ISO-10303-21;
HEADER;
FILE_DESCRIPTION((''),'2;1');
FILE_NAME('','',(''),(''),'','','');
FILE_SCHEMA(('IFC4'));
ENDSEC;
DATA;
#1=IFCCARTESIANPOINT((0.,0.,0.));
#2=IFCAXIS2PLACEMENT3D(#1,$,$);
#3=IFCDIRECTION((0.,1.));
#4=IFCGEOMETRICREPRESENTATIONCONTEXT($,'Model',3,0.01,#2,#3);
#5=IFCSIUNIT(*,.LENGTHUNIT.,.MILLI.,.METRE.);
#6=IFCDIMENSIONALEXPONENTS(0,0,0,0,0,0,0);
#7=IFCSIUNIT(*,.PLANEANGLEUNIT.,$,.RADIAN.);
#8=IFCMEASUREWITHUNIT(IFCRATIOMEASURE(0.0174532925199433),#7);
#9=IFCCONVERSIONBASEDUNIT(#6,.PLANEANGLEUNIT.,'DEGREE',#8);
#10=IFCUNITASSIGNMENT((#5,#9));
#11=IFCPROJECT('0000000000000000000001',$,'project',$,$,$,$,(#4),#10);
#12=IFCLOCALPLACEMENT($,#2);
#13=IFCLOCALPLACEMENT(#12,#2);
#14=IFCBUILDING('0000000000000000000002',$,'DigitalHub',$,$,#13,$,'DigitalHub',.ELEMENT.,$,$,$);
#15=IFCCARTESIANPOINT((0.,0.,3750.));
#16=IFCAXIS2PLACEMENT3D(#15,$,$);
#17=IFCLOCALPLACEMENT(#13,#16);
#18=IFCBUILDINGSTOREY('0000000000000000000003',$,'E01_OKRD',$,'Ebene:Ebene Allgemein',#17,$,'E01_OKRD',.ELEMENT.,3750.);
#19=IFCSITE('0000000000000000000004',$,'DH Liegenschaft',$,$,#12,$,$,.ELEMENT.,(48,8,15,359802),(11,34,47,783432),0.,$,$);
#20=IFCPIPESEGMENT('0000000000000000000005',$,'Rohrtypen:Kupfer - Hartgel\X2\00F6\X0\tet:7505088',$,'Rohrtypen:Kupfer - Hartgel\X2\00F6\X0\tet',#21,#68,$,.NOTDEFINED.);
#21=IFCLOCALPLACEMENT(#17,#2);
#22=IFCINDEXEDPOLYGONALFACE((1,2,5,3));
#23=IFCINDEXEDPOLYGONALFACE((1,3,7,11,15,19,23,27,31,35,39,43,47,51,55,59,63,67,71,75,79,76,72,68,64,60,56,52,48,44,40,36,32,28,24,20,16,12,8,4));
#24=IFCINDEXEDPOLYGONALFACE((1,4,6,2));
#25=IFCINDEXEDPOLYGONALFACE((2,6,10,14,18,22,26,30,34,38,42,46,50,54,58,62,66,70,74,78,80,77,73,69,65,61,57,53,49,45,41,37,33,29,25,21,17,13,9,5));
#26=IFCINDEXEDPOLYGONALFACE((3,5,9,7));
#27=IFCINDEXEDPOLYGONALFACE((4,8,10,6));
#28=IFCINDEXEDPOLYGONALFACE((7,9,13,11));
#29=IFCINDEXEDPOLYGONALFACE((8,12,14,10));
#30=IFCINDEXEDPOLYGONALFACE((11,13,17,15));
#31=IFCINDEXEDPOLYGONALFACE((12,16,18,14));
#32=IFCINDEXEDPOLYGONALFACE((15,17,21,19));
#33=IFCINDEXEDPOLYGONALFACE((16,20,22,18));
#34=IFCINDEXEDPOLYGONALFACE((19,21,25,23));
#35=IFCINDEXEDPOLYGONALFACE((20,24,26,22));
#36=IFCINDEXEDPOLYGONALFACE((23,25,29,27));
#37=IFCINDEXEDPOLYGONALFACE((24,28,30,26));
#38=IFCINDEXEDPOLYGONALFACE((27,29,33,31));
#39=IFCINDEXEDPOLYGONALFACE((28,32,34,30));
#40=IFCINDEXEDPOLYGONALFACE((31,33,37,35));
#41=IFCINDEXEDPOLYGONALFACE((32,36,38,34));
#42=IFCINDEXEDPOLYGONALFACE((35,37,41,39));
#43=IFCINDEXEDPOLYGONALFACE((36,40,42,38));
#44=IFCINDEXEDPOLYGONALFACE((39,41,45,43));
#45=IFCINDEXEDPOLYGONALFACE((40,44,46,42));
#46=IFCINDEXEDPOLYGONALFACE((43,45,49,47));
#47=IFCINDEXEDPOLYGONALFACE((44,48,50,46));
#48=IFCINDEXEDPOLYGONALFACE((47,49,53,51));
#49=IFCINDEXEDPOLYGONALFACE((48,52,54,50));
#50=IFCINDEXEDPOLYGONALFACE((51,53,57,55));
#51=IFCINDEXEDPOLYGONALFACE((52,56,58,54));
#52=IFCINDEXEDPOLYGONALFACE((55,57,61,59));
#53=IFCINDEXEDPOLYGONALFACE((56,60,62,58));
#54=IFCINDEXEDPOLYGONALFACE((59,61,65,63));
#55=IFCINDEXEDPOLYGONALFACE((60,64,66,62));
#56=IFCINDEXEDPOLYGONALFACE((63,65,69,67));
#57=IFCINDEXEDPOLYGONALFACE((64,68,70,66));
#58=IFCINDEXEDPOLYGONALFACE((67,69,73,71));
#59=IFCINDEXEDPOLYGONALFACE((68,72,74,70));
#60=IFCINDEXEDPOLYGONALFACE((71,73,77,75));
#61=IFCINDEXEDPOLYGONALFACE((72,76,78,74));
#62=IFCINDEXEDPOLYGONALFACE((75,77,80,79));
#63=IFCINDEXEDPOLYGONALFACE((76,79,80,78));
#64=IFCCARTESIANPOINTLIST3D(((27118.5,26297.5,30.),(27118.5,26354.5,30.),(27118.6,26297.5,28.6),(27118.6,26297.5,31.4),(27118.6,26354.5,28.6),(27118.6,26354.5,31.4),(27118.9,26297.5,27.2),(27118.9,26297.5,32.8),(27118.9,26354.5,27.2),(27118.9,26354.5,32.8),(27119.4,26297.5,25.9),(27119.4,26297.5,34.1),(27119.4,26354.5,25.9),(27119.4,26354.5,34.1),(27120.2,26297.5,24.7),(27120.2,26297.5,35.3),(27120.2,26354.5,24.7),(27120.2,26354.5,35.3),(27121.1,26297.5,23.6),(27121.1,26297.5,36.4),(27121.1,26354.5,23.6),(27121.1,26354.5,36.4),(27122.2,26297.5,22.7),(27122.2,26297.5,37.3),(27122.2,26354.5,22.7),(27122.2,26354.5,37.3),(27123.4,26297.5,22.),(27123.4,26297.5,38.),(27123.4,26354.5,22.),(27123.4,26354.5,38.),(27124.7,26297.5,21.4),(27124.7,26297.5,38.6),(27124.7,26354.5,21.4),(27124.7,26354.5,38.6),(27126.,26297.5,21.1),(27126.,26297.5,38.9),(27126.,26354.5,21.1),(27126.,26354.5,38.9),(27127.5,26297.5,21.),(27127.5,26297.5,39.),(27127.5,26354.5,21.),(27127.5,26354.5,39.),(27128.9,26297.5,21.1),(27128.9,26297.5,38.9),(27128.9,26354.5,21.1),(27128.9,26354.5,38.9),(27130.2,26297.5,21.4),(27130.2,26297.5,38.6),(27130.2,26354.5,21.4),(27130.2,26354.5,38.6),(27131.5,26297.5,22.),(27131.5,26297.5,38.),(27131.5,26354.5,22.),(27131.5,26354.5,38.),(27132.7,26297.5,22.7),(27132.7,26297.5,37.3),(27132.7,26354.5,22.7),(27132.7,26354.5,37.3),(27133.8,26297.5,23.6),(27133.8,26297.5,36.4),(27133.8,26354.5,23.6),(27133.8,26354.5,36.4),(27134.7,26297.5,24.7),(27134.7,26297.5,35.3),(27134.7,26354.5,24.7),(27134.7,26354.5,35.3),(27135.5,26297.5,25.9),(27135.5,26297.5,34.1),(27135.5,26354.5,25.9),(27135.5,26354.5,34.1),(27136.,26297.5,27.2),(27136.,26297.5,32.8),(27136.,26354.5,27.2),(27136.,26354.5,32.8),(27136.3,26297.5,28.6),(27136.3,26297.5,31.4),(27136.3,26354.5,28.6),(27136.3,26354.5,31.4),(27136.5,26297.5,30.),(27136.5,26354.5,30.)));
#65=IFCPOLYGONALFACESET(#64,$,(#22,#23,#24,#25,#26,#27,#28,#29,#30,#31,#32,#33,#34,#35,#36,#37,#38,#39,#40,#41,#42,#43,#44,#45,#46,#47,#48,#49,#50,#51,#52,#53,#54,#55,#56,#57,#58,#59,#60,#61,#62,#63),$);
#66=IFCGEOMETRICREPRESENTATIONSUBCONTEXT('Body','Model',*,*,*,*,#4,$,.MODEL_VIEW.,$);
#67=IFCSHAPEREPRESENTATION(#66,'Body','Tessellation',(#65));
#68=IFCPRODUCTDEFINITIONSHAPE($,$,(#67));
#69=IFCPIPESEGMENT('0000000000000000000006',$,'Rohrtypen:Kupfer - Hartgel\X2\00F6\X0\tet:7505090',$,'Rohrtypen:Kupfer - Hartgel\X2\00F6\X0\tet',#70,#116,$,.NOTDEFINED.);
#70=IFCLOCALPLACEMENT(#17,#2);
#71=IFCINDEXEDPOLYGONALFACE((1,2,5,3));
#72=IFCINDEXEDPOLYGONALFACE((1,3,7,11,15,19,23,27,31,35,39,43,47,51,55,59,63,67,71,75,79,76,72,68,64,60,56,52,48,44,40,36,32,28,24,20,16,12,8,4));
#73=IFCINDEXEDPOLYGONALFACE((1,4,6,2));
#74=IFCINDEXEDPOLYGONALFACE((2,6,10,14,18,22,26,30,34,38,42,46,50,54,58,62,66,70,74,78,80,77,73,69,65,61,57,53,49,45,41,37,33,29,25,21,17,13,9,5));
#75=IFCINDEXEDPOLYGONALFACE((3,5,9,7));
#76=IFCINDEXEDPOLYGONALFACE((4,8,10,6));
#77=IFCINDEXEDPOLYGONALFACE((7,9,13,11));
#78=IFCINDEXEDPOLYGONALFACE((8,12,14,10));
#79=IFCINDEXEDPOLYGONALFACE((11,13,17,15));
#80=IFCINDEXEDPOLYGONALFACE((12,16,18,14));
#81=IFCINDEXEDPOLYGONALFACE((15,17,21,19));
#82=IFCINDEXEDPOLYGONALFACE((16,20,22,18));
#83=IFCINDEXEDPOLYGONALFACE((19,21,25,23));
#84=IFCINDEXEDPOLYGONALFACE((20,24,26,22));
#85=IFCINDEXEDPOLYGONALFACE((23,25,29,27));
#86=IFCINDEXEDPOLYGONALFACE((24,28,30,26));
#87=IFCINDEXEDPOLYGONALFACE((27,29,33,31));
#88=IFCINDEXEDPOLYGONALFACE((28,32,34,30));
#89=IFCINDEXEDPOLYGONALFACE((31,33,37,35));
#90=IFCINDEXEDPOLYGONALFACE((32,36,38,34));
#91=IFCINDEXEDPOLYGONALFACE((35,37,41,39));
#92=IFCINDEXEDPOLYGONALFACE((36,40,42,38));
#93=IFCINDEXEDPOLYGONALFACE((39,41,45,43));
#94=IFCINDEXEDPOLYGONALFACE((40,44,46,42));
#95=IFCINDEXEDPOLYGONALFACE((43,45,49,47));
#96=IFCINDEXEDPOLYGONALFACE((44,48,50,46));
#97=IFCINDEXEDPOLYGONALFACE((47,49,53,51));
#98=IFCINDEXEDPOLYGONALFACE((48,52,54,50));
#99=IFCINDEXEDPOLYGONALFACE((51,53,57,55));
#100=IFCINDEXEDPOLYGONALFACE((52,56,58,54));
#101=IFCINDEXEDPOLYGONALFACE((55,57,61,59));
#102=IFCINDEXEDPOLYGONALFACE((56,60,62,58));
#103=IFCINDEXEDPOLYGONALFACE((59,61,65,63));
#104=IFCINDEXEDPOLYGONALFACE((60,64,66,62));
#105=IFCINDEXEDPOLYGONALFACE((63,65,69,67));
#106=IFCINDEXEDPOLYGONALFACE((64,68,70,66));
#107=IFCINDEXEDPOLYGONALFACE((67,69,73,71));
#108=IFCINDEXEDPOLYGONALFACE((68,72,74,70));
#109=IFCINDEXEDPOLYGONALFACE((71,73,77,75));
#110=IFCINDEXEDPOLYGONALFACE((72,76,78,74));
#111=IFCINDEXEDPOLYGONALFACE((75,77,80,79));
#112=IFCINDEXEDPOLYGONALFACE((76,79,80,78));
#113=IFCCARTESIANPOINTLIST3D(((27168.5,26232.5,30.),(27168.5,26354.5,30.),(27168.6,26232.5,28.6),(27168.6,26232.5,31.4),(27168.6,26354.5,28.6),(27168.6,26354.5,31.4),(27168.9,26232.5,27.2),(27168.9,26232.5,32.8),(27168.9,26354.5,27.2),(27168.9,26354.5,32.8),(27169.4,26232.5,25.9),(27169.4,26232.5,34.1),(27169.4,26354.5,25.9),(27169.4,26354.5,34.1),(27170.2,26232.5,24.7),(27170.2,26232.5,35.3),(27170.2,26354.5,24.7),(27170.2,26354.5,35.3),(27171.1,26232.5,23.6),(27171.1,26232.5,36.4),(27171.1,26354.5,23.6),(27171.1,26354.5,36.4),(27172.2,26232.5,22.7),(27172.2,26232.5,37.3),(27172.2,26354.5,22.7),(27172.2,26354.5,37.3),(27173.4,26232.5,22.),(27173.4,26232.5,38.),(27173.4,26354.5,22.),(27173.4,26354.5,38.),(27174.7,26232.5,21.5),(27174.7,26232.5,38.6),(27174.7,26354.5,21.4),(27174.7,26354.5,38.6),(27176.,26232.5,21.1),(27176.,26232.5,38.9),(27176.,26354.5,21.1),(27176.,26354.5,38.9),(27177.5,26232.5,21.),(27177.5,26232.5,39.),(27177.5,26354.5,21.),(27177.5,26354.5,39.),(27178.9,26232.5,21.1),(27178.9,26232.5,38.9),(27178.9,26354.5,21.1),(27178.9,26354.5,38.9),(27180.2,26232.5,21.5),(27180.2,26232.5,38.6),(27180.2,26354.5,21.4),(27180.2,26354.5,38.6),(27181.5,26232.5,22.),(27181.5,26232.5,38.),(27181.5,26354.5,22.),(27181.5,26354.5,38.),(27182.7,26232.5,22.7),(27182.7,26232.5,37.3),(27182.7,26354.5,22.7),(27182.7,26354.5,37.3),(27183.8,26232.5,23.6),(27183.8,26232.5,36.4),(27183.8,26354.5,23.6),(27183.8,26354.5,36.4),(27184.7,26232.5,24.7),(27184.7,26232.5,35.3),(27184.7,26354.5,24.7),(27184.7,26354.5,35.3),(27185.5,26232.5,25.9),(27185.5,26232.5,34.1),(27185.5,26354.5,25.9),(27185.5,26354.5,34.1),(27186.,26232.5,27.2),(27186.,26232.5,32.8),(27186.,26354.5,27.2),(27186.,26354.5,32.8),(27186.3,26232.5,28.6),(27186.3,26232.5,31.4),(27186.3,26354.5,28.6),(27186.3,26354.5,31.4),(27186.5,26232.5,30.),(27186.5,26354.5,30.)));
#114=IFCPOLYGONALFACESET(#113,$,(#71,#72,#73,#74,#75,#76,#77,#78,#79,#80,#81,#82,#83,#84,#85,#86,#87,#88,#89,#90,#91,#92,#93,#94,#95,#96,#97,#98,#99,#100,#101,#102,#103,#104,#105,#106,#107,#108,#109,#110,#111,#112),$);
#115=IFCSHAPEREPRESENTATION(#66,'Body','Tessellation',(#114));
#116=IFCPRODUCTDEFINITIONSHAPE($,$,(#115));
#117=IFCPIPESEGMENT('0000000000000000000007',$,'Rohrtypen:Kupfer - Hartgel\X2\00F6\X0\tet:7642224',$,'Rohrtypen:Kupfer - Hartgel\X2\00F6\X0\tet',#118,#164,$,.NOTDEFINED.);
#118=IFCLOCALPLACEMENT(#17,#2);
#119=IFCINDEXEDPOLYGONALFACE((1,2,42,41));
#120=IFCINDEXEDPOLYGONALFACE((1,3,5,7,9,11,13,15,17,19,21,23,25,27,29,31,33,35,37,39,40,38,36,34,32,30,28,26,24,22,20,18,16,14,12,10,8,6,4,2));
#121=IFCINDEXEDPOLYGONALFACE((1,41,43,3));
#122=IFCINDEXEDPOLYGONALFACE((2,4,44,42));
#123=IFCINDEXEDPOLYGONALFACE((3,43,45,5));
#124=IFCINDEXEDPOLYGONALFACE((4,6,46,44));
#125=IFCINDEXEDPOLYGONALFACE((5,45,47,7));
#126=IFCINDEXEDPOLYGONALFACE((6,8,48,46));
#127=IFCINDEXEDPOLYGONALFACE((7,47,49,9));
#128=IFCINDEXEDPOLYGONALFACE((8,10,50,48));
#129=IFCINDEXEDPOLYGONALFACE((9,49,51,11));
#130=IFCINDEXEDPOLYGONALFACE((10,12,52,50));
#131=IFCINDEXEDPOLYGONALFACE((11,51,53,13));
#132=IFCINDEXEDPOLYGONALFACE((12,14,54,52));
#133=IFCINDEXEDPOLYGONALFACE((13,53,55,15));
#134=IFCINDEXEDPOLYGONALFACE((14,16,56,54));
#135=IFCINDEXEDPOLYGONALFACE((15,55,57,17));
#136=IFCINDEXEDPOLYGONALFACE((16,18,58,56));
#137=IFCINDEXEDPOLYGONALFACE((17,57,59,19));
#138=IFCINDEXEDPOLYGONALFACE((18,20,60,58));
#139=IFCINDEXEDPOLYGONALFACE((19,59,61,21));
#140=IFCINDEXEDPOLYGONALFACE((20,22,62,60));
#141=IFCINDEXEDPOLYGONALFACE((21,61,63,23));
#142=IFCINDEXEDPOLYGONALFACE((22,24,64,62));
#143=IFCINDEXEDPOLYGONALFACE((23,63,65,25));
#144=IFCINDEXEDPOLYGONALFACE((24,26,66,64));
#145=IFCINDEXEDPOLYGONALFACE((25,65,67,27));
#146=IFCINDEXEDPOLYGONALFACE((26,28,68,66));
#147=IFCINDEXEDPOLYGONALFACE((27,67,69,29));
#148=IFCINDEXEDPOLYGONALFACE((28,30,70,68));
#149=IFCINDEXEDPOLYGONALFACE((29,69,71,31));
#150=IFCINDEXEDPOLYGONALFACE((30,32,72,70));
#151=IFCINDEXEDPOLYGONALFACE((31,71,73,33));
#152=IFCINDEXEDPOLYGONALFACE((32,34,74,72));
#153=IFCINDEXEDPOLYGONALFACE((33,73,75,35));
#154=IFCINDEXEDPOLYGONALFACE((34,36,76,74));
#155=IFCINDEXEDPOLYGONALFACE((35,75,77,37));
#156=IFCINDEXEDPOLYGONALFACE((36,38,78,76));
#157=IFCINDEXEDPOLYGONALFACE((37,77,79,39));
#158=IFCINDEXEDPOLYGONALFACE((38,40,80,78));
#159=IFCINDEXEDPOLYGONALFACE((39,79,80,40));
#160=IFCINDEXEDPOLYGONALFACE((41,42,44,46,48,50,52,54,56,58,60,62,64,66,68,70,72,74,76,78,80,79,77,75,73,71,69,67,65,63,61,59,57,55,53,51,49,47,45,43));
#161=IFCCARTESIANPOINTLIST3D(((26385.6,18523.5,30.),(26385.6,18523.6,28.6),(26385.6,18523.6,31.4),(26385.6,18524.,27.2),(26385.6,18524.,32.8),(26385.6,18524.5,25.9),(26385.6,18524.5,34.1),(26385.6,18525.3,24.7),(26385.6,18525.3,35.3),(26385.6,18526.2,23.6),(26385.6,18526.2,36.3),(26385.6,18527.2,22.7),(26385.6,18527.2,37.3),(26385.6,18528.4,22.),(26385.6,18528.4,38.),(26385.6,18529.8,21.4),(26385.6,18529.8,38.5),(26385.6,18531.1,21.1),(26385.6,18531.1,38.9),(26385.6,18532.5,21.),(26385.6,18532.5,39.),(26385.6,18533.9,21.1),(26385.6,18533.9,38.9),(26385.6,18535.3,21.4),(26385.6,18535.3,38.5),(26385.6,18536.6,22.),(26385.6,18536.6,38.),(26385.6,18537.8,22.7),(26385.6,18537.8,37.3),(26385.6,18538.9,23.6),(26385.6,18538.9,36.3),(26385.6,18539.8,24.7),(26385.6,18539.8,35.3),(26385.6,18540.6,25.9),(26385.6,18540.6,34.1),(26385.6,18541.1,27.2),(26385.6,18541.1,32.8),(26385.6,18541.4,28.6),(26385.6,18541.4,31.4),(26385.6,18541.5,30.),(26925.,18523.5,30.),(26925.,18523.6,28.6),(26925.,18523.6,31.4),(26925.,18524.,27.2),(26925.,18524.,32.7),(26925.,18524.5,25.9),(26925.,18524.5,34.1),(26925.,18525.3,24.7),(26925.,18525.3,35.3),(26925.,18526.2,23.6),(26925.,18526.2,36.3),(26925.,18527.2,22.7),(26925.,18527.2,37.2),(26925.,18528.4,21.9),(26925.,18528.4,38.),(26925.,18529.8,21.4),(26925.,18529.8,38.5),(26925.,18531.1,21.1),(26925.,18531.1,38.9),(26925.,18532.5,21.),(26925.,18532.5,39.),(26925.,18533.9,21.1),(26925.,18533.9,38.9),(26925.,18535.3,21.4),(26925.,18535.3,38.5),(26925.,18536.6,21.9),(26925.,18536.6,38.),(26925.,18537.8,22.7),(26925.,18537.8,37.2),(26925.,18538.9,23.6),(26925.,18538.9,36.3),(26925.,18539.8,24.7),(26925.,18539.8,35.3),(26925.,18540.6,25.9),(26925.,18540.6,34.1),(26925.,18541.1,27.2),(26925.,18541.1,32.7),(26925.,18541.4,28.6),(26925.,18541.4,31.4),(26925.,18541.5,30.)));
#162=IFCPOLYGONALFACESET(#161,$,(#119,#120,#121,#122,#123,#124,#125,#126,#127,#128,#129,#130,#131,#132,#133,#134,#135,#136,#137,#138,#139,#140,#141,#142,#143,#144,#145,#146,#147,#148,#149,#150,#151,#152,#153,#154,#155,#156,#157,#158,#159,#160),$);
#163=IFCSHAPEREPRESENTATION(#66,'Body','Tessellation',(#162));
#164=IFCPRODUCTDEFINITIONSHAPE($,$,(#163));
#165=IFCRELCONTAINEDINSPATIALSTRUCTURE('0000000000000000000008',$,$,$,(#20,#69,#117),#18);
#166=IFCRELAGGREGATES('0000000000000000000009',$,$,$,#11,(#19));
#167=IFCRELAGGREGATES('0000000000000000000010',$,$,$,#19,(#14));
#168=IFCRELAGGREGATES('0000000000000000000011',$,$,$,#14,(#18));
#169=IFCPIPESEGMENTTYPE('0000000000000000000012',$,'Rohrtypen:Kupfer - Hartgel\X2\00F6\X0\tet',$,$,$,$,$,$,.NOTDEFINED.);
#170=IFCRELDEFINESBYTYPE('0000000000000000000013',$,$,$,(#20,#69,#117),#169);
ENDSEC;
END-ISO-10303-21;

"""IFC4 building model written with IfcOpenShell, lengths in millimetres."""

from ifc_helpers import new_model, entity, si_unit, converted_unit, direction, frame, origin, place, context, subcontext, project, spatial, indexed_curve, outline, extrude, type_object, element, save


model = new_model("IFC4")

# Units and contexts
model_context = context("Model", 3, precision=0.01, world=origin(), true_north=direction((0.0, 1.0)))
body_context = subcontext(model_context, "Body", "Model", "MODEL_VIEW")
ifc_project = project(units=[si_unit("LENGTHUNIT", "METRE", prefix="MILLI"), converted_unit("PLANEANGLEUNIT", "DEGREE", entity("IfcRatioMeasure", 0.0174532925199433), si_unit("PLANEANGLEUNIT", "RADIAN"), dimensions=[0, 0, 0, 0, 0, 0, 0])], contexts=[model_context])

# Site, building, storey
site_placement = place(None, origin())
site = spatial("IfcSite", under=ifc_project, at=site_placement, Name="DH Liegenschaft", CompositionType="ELEMENT", RefLatitude=(48, 8, 15, 359802), RefLongitude=(11, 34, 47, 783432), RefElevation=0.0)
building_placement = place(site_placement, origin())
building = spatial("IfcBuilding", under=site, at=building_placement, Name="DigitalHub", LongName="DigitalHub", CompositionType="ELEMENT")
storey_placement = place(building_placement, frame((0.0, 0.0, 3750.0)))
storey = spatial("IfcBuildingStorey", under=building, at=storey_placement, Name="E01_OKRD", ObjectType="Ebene:Ebene Allgemein", LongName="E01_OKRD", CompositionType="ELEMENT", Elevation=3750.0)

# Pipe segments
pipe_segment_type = type_object("IfcPipeSegmentType", Name="Rohrtypen:Kupfer - Hartgelötet", PredefinedType="NOTDEFINED")
pipe_segment_1_placement = place(storey_placement, frame((27116.9, 26297.5, 19.4)))
element("IfcPipeSegment", 1, at=pipe_segment_1_placement, inside=storey, type_object=pipe_segment_type, Name="Rohrtypen:Kupfer - Hartgelötet:7505088", ObjectType="Rohrtypen:Kupfer - Hartgelötet", PredefinedType="NOTDEFINED", context=body_context, shape_type="SweptSolid", body=[
    extrude(outline(indexed_curve([(9.0, 0.0), (8.9, 1.4), (8.6, 2.8), (8.0, 4.1), (7.3, 5.3), (6.4, 6.4), (5.3, 7.3), (4.1, 8.0), (2.8, 8.6), (1.4, 8.9), (0.0, 9.0), (-1.4, 8.9), (-2.8, 8.6), (-4.1, 8.0), (-5.3, 7.3), (-6.4, 6.4), (-7.3, 5.3), (-8.0, 4.1), (-8.6, 2.8), (-8.9, 1.4), (-9.0, 0.0), (-8.9, -1.4), (-8.6, -2.8), (-8.0, -4.1), (-7.3, -5.3), (-6.4, -6.4), (-5.3, -7.3), (-4.1, -8.0), (-2.8, -8.6), (-1.4, -8.9), (0.0, -9.0), (1.4, -8.9), (2.8, -8.6), (4.1, -8.0), (5.3, -7.3), (6.4, -6.4), (7.3, -5.3), (8.0, -4.1), (8.6, -2.8), (8.9, -1.4), (9.0, 0.0)], self_intersect=False)), frame((10.6, 0.0, 10.6), z_axis=(0.0, 1.0, 0.0), x_axis=(-1.0, 0.0, 0.0)), (0.0, 0.0, 1.0), 57.0),
])
pipe_segment_2_placement = place(storey_placement, frame((27166.9, 26232.5, 19.4)))
element("IfcPipeSegment", 2, at=pipe_segment_2_placement, inside=storey, type_object=pipe_segment_type, Name="Rohrtypen:Kupfer - Hartgelötet:7505090", ObjectType="Rohrtypen:Kupfer - Hartgelötet", PredefinedType="NOTDEFINED", context=body_context, shape_type="SweptSolid", body=[
    extrude(outline(indexed_curve([(9.0, 0.0), (8.9, 1.4), (8.6, 2.8), (8.0, 4.1), (7.3, 5.3), (6.4, 6.4), (5.3, 7.3), (4.1, 8.0), (2.8, 8.6), (1.4, 8.9), (0.0, 9.0), (-1.4, 8.9), (-2.8, 8.6), (-4.1, 8.0), (-5.3, 7.3), (-6.4, 6.4), (-7.3, 5.3), (-8.0, 4.1), (-8.6, 2.8), (-8.9, 1.4), (-9.0, 0.0), (-8.9, -1.4), (-8.6, -2.8), (-8.0, -4.1), (-7.3, -5.3), (-6.4, -6.4), (-5.3, -7.3), (-4.1, -8.0), (-2.8, -8.6), (-1.4, -8.9), (0.0, -9.0), (1.4, -8.9), (2.8, -8.6), (4.1, -8.0), (5.3, -7.3), (6.4, -6.4), (7.3, -5.3), (8.0, -4.1), (8.6, -2.8), (8.9, -1.4), (9.0, 0.0)], self_intersect=False)), frame((10.6, 0.0, 10.6), z_axis=(0.0, 1.0, -0.000093), x_axis=(-1.0, 0.0, 0.0)), (0.0, 0.0, 1.0), 122.0),
])
pipe_segment_3_placement = place(storey_placement, frame((26385.6, 18521.9, 19.4)))
element("IfcPipeSegment", 3, at=pipe_segment_3_placement, inside=storey, type_object=pipe_segment_type, Name="Rohrtypen:Kupfer - Hartgelötet:7642224", ObjectType="Rohrtypen:Kupfer - Hartgelötet", PredefinedType="NOTDEFINED", context=body_context, shape_type="SweptSolid", body=[
    extrude(outline(indexed_curve([(9.0, 0.0), (8.9, 1.4), (8.6, 2.8), (8.0, 4.1), (7.3, 5.3), (6.4, 6.4), (5.3, 7.3), (4.1, 8.0), (2.8, 8.6), (1.4, 8.9), (0.0, 9.0), (-1.4, 8.9), (-2.8, 8.6), (-4.1, 8.0), (-5.3, 7.3), (-6.4, 6.4), (-7.3, 5.3), (-8.0, 4.1), (-8.6, 2.8), (-8.9, 1.4), (-9.0, 0.0), (-8.9, -1.4), (-8.6, -2.8), (-8.0, -4.1), (-7.3, -5.3), (-6.4, -6.4), (-5.3, -7.3), (-4.1, -8.0), (-2.8, -8.6), (-1.4, -8.9), (0.0, -9.0), (1.4, -8.9), (2.8, -8.6), (4.1, -8.0), (5.3, -7.3), (6.4, -6.4), (7.3, -5.3), (8.0, -4.1), (8.6, -2.8), (8.9, -1.4), (9.0, 0.0)], self_intersect=False)), frame((539.4, 10.6, 10.6), z_axis=(-1.0, 0.0, 0.000029), x_axis=(0.0, 1.0, 0.0)), (0.0, 0.0, 1.0), 539.4),
])

save(model, "model.ifc")
